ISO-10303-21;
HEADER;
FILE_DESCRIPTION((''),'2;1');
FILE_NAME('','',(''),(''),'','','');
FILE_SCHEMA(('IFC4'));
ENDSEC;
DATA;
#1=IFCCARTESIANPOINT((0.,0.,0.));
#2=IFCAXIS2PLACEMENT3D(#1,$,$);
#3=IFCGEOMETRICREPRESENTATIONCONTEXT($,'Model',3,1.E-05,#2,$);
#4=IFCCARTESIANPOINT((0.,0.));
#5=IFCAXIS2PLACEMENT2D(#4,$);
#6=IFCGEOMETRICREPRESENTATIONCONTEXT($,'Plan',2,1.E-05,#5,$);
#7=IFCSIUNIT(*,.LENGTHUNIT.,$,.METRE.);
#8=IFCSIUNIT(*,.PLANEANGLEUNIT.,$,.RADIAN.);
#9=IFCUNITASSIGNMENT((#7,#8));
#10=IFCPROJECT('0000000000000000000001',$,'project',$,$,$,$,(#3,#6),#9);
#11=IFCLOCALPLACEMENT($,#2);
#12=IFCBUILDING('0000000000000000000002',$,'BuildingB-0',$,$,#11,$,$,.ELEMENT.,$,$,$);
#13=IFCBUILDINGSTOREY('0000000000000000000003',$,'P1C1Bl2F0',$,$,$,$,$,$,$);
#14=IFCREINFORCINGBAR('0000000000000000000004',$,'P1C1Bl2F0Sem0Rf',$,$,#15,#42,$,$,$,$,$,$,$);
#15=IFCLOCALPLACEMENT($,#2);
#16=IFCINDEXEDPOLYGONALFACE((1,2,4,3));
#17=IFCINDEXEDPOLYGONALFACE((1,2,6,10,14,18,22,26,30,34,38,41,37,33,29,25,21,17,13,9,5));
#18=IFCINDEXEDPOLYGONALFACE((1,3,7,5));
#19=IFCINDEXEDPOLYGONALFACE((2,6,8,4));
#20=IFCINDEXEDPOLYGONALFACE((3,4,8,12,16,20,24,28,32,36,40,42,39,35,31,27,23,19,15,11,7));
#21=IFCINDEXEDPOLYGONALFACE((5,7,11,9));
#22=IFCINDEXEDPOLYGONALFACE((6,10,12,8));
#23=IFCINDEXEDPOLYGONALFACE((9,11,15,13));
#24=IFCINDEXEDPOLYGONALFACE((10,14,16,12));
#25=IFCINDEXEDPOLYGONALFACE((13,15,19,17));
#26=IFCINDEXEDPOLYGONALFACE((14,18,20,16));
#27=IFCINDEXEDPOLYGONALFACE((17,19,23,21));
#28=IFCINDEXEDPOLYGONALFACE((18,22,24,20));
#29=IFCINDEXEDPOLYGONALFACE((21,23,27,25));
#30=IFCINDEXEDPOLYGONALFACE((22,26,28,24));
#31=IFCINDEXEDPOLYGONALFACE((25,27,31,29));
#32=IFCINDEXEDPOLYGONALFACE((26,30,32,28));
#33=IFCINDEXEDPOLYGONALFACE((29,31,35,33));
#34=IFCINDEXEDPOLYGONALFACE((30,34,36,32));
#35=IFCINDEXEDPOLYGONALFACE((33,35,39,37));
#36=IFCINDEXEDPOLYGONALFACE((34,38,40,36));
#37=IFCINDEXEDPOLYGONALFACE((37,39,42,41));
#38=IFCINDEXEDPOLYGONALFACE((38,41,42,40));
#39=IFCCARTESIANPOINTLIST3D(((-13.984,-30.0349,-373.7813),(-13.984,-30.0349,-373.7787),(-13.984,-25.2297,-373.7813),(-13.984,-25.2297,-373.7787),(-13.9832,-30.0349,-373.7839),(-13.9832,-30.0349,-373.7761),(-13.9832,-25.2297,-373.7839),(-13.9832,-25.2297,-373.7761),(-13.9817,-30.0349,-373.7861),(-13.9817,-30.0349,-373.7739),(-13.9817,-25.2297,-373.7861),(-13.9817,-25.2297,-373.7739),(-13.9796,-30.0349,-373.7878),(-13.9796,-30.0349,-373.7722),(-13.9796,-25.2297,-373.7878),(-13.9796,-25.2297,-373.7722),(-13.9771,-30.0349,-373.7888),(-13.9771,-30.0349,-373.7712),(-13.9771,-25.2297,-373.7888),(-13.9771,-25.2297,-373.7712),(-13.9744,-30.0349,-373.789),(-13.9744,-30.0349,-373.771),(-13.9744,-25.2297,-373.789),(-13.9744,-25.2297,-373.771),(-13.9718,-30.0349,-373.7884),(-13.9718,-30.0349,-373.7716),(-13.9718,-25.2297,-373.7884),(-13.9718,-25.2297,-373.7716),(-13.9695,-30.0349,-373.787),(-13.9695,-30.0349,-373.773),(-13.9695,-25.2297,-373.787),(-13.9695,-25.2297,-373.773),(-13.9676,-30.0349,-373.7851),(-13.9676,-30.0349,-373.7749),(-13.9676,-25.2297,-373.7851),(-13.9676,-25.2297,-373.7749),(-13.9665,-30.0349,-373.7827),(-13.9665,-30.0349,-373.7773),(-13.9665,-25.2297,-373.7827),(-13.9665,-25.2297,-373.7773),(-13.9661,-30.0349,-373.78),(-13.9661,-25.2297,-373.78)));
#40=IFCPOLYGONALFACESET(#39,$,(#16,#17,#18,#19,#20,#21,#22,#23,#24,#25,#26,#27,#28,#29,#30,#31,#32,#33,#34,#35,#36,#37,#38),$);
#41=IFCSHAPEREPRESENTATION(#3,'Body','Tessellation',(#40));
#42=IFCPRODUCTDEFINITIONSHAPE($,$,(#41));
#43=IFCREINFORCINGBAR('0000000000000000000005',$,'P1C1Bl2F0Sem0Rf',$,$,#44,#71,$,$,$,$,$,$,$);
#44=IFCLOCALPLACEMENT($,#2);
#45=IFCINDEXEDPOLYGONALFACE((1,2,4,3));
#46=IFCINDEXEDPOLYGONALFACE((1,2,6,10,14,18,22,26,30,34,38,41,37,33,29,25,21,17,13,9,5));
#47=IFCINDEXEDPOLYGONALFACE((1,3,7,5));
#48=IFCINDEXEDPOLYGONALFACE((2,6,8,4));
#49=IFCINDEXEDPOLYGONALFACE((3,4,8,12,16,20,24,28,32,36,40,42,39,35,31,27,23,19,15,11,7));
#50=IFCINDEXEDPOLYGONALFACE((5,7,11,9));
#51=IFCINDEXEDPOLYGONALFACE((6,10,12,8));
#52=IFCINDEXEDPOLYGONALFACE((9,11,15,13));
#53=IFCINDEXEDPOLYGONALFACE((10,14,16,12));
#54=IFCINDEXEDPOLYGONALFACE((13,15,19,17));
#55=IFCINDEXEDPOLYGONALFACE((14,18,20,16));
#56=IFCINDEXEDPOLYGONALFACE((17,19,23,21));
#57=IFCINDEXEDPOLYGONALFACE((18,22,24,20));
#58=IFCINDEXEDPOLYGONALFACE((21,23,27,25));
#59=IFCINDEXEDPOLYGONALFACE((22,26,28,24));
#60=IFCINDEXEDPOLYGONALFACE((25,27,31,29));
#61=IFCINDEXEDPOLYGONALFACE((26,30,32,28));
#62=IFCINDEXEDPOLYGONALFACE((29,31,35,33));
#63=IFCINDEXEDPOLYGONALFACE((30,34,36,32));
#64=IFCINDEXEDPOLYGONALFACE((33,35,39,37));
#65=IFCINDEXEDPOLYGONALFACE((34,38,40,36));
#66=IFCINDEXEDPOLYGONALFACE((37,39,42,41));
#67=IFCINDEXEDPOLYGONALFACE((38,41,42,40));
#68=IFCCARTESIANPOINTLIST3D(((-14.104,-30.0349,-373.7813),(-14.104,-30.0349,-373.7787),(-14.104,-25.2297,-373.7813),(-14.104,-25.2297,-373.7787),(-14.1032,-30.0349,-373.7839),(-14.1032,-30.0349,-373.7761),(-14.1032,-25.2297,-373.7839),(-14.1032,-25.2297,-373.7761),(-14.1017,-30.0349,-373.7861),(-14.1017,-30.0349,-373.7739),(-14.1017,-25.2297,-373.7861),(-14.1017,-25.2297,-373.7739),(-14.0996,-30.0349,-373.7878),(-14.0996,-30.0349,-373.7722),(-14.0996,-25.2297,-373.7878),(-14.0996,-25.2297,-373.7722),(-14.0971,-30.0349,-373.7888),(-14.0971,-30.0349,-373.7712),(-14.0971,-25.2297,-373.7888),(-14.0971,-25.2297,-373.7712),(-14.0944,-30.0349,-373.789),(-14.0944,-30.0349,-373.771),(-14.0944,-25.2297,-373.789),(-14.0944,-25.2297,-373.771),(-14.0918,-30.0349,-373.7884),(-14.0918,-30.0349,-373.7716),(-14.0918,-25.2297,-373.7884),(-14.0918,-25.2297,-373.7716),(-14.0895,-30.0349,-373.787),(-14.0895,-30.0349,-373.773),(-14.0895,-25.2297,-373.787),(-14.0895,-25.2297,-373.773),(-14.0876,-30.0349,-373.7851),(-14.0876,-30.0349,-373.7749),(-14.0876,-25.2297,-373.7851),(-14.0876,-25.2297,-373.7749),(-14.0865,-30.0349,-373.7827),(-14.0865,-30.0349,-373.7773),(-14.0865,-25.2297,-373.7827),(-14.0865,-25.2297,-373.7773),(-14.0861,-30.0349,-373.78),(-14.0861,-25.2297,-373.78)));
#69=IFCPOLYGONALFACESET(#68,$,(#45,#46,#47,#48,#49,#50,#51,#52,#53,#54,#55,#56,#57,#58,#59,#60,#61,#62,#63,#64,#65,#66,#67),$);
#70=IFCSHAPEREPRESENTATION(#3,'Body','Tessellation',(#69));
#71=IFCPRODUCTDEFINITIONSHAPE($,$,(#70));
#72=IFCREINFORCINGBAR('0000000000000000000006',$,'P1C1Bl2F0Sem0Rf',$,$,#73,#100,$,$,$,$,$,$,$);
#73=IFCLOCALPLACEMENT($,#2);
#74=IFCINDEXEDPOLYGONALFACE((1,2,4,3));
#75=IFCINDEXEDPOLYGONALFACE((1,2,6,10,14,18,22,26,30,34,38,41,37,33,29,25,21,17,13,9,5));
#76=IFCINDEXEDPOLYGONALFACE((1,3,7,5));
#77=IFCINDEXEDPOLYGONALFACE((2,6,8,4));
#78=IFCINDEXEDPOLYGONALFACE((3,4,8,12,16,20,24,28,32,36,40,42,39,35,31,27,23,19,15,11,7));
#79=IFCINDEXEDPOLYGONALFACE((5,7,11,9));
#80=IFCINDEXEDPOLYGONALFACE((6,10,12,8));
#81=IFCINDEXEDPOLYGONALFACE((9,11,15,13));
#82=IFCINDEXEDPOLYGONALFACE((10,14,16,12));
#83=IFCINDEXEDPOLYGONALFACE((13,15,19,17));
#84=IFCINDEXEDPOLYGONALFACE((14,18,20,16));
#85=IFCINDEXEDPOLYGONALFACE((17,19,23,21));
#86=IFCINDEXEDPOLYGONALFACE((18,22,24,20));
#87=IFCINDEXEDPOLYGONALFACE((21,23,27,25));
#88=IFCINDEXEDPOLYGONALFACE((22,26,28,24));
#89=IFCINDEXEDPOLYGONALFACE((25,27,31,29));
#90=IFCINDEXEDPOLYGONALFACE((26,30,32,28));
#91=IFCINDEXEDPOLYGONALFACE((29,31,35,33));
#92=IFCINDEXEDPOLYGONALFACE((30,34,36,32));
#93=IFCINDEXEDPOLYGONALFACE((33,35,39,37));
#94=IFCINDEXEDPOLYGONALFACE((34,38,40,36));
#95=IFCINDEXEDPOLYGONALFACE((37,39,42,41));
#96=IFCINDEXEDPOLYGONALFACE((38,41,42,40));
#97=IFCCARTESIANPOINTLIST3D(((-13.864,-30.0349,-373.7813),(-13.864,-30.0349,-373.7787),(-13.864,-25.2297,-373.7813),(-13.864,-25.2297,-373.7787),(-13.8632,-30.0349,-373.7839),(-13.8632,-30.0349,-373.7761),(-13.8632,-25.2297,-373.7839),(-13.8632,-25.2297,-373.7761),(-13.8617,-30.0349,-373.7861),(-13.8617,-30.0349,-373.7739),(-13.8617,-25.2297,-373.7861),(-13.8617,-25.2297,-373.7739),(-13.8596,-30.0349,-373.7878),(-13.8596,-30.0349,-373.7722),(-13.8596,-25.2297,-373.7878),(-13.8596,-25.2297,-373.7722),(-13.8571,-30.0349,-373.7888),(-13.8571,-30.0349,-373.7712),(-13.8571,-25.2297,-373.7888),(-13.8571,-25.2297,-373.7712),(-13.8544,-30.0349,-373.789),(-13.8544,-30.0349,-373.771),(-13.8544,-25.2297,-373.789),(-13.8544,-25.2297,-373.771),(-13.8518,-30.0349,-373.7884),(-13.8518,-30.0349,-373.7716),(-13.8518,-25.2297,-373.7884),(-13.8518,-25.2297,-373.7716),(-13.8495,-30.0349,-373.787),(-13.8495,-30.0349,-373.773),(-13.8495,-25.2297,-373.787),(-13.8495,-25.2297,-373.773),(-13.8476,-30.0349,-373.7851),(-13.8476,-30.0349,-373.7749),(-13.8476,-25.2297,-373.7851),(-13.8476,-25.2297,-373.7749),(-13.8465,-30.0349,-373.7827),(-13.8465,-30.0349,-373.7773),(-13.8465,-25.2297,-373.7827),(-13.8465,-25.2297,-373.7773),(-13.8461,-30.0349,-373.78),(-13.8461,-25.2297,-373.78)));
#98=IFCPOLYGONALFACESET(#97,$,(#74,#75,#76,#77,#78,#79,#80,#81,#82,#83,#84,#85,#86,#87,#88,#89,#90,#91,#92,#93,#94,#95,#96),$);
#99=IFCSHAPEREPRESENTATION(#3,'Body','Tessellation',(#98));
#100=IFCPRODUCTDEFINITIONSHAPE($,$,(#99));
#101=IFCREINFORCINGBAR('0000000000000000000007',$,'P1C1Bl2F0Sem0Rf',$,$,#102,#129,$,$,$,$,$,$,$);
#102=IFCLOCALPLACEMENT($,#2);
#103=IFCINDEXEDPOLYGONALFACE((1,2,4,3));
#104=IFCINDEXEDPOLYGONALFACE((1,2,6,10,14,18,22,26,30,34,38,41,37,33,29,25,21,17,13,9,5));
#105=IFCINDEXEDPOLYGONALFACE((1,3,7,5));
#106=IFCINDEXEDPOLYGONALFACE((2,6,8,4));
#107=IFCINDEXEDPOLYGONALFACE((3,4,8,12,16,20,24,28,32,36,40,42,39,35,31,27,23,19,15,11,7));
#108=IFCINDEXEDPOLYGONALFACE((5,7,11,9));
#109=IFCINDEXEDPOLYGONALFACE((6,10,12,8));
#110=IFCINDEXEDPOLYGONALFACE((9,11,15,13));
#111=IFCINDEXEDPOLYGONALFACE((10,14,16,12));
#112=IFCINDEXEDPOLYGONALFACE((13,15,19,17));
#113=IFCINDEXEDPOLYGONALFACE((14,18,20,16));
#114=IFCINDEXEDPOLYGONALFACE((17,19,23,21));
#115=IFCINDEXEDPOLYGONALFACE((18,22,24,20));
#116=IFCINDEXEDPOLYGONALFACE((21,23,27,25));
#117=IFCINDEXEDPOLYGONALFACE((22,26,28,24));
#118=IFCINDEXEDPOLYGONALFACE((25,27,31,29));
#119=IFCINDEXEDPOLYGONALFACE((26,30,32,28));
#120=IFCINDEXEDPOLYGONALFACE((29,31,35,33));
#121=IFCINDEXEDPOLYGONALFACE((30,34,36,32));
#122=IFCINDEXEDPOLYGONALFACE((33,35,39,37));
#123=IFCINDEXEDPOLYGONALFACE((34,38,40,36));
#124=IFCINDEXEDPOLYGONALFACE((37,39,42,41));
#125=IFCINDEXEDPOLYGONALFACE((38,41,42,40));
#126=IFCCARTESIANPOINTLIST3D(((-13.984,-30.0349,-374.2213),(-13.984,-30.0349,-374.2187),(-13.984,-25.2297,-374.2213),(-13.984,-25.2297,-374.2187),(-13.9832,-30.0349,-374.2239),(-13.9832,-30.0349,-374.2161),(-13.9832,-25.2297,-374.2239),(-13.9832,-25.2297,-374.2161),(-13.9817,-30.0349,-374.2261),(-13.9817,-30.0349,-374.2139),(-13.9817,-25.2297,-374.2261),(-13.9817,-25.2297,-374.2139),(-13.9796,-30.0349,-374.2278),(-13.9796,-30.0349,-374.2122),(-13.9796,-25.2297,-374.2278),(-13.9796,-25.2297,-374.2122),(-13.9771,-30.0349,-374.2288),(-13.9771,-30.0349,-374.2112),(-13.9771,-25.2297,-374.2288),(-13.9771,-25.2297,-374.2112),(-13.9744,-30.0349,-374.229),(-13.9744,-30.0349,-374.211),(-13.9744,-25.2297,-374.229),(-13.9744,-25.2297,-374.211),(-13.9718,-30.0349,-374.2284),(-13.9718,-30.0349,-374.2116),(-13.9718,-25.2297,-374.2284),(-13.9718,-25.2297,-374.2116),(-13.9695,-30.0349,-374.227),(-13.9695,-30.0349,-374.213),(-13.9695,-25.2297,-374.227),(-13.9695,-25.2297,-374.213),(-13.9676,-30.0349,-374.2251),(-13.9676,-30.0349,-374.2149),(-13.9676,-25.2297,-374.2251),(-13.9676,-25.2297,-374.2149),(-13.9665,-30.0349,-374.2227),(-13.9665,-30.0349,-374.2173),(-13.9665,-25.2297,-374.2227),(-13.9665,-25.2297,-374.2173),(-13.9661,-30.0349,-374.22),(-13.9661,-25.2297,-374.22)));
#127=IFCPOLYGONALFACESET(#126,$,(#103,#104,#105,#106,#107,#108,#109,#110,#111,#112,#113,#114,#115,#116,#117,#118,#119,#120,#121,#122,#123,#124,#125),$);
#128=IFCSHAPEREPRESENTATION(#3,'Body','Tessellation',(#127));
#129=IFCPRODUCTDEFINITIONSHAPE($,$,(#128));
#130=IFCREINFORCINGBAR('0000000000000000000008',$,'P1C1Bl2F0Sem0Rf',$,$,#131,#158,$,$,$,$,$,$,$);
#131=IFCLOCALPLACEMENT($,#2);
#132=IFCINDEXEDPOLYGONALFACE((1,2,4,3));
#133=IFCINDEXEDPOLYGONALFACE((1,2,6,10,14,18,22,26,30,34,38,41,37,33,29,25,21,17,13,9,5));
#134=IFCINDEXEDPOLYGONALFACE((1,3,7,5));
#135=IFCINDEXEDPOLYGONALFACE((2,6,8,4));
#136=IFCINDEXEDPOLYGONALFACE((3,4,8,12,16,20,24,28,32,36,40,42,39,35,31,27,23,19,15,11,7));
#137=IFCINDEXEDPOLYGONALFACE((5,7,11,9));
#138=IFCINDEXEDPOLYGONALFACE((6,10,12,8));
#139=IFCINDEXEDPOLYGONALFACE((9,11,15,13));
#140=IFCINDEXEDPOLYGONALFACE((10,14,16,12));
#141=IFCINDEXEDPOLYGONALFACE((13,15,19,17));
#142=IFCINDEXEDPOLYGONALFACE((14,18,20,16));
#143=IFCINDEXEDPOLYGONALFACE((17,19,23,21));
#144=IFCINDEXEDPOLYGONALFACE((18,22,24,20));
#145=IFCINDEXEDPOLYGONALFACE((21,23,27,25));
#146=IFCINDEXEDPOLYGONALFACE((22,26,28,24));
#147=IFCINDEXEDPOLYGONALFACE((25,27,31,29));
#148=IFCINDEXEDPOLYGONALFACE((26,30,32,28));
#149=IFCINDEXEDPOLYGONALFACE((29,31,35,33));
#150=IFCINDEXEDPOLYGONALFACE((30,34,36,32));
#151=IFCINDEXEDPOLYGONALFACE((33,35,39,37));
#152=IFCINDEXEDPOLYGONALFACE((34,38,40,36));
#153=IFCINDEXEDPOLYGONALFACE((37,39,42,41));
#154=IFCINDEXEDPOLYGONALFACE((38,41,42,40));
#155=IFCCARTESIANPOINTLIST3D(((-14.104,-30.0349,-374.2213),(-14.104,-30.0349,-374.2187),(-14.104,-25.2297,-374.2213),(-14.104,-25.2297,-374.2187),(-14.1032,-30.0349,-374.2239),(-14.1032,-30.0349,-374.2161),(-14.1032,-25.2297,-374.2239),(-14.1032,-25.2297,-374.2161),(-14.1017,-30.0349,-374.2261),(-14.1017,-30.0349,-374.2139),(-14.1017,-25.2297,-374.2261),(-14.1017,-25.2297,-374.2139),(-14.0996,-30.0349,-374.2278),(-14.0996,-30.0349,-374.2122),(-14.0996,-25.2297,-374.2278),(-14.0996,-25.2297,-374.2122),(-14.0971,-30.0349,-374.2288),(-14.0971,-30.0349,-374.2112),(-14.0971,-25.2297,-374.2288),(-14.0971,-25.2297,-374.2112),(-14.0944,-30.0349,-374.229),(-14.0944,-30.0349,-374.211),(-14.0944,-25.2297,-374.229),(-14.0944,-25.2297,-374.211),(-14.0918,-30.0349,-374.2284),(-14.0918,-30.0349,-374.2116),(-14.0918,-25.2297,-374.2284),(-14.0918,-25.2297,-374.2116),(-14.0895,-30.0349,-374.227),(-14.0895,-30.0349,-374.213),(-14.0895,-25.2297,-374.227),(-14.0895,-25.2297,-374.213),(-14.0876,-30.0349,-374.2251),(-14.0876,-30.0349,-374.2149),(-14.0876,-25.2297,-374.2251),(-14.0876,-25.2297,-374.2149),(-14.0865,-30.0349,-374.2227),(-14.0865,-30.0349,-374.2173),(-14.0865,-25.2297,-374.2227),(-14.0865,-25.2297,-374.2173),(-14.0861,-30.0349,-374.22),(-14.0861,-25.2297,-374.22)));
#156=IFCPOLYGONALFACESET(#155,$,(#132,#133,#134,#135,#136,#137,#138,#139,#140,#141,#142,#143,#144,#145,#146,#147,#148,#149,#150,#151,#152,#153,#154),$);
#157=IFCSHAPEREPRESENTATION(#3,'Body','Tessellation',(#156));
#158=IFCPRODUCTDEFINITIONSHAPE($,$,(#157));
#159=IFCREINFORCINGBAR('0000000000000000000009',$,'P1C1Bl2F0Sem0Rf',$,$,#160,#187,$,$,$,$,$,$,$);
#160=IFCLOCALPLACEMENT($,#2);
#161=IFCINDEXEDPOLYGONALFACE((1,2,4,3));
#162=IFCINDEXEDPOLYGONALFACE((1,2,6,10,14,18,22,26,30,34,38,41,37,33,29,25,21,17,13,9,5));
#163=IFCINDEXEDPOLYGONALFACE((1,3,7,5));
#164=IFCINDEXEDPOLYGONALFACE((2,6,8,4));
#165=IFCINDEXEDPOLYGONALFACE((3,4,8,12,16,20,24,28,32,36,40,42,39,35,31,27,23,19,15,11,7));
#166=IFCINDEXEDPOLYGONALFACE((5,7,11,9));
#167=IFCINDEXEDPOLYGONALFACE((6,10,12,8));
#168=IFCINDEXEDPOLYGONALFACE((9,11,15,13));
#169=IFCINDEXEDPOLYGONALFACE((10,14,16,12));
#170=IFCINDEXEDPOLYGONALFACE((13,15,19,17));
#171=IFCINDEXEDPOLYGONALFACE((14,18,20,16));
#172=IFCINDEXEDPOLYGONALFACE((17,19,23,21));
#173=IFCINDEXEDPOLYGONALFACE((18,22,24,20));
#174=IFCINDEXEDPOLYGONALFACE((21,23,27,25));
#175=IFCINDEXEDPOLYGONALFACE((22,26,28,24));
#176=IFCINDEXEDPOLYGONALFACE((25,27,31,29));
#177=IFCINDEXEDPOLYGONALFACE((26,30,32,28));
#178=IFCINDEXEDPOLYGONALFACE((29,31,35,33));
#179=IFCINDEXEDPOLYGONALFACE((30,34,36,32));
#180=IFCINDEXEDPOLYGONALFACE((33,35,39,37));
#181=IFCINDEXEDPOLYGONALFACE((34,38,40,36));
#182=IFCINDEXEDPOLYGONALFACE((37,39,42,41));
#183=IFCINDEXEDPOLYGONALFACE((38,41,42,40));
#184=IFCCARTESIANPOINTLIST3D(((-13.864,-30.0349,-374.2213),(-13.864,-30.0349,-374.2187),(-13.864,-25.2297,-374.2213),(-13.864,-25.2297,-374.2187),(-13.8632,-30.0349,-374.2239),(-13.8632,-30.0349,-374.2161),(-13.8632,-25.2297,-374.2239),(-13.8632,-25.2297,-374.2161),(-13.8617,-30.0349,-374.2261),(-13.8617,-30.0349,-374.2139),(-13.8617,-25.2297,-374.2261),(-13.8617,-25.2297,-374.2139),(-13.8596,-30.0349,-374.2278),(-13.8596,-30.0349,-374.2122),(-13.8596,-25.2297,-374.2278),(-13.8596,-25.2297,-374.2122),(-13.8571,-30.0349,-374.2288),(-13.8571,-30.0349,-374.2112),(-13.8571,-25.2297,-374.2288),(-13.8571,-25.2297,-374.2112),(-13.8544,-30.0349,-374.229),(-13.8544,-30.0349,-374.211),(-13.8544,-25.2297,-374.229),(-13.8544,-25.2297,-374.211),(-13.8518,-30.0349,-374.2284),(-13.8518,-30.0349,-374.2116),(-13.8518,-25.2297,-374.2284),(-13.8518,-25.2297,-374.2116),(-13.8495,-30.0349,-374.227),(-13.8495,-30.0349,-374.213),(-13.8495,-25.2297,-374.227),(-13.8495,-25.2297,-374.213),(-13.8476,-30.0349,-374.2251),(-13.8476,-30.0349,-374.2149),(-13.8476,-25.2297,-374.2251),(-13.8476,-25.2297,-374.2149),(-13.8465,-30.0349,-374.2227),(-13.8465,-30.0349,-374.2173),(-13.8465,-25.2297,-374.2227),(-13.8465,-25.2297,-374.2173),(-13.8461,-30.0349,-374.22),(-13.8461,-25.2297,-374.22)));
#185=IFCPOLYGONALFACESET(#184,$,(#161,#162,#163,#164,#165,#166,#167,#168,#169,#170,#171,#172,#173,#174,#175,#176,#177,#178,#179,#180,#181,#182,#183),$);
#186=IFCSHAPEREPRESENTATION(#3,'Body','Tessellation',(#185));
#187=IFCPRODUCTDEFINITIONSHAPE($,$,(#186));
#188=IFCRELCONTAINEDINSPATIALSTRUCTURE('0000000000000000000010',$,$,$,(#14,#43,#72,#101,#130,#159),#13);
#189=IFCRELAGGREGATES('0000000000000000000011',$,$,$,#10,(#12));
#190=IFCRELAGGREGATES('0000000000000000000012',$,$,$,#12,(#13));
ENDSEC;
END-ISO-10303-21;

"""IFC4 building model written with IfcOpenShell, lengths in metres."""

from ifc_helpers import new_model, entity, si_unit, origin, origin_2d, place, context, project, spatial, element, save


model = new_model("IFC4")

# Units and contexts
model_context = context("Model", 3, precision=1e-05, world=origin())
plan_context = context("Plan", 2, precision=1e-05, world=origin_2d())
ifc_project = project(units=[si_unit("LENGTHUNIT", "METRE"), si_unit("PLANEANGLEUNIT", "RADIAN")], contexts=[model_context, plan_context])

# Building, storey
building_placement = place(None, origin())
building = spatial("IfcBuilding", under=ifc_project, at=building_placement, Name="BuildingB-0", CompositionType="ELEMENT")
storey = spatial("IfcBuildingStorey", under=building, Name="P1C1Bl2F0")

# Reinforcing bars
element("IfcReinforcingBar", 1, inside=storey, Name="P1C1Bl2F0Sem0Rf", context=model_context, shape_type="SweptSolid", body=[
    entity("IfcSurfaceCurveSweptAreaSolid", entity("IfcCircleProfileDef", "AREA", None, None, 0.009), None, entity("IfcPolyline", [entity("IfcCartesianPoint", [13.9751, 25.2297, 373.78]), entity("IfcCartesianPoint", [13.9751, 30.0349, 373.78])]), None, None, entity("IfcPlane", entity("IfcAxis2Placement3D", entity("IfcCartesianPoint", [13.9751, 25.2297, 373.78]), entity("IfcDirection", [0.0, 0.0, 1.0]), entity("IfcDirection", [1.0, 0.0, 0.0])))),
])
element("IfcReinforcingBar", 2, inside=storey, Name="P1C1Bl2F0Sem0Rf", context=model_context, shape_type="SweptSolid", body=[
    entity("IfcSurfaceCurveSweptAreaSolid", entity("IfcCircleProfileDef", "AREA", None, None, 0.009), None, entity("IfcPolyline", [entity("IfcCartesianPoint", [14.0951, 25.2297, 373.78]), entity("IfcCartesianPoint", [14.0951, 30.0349, 373.78])]), None, None, entity("IfcPlane", entity("IfcAxis2Placement3D", entity("IfcCartesianPoint", [14.0951, 25.2297, 373.78]), entity("IfcDirection", [0.0, 0.0, 1.0]), entity("IfcDirection", [1.0, 0.0, 0.0])))),
])
element("IfcReinforcingBar", 3, inside=storey, Name="P1C1Bl2F0Sem0Rf", context=model_context, shape_type="SweptSolid", body=[
    entity("IfcSurfaceCurveSweptAreaSolid", entity("IfcCircleProfileDef", "AREA", None, None, 0.009), None, entity("IfcPolyline", [entity("IfcCartesianPoint", [13.8551, 25.2297, 373.78]), entity("IfcCartesianPoint", [13.8551, 30.0349, 373.78])]), None, None, entity("IfcPlane", entity("IfcAxis2Placement3D", entity("IfcCartesianPoint", [13.8551, 25.2297, 373.78]), entity("IfcDirection", [0.0, 0.0, 1.0]), entity("IfcDirection", [1.0, 0.0, 0.0])))),
])
element("IfcReinforcingBar", 4, inside=storey, Name="P1C1Bl2F0Sem0Rf", context=model_context, shape_type="SweptSolid", body=[
    entity("IfcSurfaceCurveSweptAreaSolid", entity("IfcCircleProfileDef", "AREA", None, None, 0.009), None, entity("IfcPolyline", [entity("IfcCartesianPoint", [13.9751, 25.2297, 374.22]), entity("IfcCartesianPoint", [13.9751, 30.0349, 374.22])]), None, None, entity("IfcPlane", entity("IfcAxis2Placement3D", entity("IfcCartesianPoint", [13.9751, 25.2297, 374.22]), entity("IfcDirection", [0.0, 0.0, 1.0]), entity("IfcDirection", [1.0, 0.0, 0.0])))),
])
element("IfcReinforcingBar", 5, inside=storey, Name="P1C1Bl2F0Sem0Rf", context=model_context, shape_type="SweptSolid", body=[
    entity("IfcSurfaceCurveSweptAreaSolid", entity("IfcCircleProfileDef", "AREA", None, None, 0.009), None, entity("IfcPolyline", [entity("IfcCartesianPoint", [14.0951, 25.2297, 374.22]), entity("IfcCartesianPoint", [14.0951, 30.0349, 374.22])]), None, None, entity("IfcPlane", entity("IfcAxis2Placement3D", entity("IfcCartesianPoint", [14.0951, 25.2297, 374.22]), entity("IfcDirection", [0.0, 0.0, 1.0]), entity("IfcDirection", [1.0, 0.0, 0.0])))),
])
element("IfcReinforcingBar", 6, inside=storey, Name="P1C1Bl2F0Sem0Rf", context=model_context, shape_type="SweptSolid", body=[
    entity("IfcSurfaceCurveSweptAreaSolid", entity("IfcCircleProfileDef", "AREA", None, None, 0.009), None, entity("IfcPolyline", [entity("IfcCartesianPoint", [13.8551, 25.2297, 374.22]), entity("IfcCartesianPoint", [13.8551, 30.0349, 374.22])]), None, None, entity("IfcPlane", entity("IfcAxis2Placement3D", entity("IfcCartesianPoint", [13.8551, 25.2297, 374.22]), entity("IfcDirection", [0.0, 0.0, 1.0]), entity("IfcDirection", [1.0, 0.0, 0.0])))),
])

save(model, "model.ifc")
